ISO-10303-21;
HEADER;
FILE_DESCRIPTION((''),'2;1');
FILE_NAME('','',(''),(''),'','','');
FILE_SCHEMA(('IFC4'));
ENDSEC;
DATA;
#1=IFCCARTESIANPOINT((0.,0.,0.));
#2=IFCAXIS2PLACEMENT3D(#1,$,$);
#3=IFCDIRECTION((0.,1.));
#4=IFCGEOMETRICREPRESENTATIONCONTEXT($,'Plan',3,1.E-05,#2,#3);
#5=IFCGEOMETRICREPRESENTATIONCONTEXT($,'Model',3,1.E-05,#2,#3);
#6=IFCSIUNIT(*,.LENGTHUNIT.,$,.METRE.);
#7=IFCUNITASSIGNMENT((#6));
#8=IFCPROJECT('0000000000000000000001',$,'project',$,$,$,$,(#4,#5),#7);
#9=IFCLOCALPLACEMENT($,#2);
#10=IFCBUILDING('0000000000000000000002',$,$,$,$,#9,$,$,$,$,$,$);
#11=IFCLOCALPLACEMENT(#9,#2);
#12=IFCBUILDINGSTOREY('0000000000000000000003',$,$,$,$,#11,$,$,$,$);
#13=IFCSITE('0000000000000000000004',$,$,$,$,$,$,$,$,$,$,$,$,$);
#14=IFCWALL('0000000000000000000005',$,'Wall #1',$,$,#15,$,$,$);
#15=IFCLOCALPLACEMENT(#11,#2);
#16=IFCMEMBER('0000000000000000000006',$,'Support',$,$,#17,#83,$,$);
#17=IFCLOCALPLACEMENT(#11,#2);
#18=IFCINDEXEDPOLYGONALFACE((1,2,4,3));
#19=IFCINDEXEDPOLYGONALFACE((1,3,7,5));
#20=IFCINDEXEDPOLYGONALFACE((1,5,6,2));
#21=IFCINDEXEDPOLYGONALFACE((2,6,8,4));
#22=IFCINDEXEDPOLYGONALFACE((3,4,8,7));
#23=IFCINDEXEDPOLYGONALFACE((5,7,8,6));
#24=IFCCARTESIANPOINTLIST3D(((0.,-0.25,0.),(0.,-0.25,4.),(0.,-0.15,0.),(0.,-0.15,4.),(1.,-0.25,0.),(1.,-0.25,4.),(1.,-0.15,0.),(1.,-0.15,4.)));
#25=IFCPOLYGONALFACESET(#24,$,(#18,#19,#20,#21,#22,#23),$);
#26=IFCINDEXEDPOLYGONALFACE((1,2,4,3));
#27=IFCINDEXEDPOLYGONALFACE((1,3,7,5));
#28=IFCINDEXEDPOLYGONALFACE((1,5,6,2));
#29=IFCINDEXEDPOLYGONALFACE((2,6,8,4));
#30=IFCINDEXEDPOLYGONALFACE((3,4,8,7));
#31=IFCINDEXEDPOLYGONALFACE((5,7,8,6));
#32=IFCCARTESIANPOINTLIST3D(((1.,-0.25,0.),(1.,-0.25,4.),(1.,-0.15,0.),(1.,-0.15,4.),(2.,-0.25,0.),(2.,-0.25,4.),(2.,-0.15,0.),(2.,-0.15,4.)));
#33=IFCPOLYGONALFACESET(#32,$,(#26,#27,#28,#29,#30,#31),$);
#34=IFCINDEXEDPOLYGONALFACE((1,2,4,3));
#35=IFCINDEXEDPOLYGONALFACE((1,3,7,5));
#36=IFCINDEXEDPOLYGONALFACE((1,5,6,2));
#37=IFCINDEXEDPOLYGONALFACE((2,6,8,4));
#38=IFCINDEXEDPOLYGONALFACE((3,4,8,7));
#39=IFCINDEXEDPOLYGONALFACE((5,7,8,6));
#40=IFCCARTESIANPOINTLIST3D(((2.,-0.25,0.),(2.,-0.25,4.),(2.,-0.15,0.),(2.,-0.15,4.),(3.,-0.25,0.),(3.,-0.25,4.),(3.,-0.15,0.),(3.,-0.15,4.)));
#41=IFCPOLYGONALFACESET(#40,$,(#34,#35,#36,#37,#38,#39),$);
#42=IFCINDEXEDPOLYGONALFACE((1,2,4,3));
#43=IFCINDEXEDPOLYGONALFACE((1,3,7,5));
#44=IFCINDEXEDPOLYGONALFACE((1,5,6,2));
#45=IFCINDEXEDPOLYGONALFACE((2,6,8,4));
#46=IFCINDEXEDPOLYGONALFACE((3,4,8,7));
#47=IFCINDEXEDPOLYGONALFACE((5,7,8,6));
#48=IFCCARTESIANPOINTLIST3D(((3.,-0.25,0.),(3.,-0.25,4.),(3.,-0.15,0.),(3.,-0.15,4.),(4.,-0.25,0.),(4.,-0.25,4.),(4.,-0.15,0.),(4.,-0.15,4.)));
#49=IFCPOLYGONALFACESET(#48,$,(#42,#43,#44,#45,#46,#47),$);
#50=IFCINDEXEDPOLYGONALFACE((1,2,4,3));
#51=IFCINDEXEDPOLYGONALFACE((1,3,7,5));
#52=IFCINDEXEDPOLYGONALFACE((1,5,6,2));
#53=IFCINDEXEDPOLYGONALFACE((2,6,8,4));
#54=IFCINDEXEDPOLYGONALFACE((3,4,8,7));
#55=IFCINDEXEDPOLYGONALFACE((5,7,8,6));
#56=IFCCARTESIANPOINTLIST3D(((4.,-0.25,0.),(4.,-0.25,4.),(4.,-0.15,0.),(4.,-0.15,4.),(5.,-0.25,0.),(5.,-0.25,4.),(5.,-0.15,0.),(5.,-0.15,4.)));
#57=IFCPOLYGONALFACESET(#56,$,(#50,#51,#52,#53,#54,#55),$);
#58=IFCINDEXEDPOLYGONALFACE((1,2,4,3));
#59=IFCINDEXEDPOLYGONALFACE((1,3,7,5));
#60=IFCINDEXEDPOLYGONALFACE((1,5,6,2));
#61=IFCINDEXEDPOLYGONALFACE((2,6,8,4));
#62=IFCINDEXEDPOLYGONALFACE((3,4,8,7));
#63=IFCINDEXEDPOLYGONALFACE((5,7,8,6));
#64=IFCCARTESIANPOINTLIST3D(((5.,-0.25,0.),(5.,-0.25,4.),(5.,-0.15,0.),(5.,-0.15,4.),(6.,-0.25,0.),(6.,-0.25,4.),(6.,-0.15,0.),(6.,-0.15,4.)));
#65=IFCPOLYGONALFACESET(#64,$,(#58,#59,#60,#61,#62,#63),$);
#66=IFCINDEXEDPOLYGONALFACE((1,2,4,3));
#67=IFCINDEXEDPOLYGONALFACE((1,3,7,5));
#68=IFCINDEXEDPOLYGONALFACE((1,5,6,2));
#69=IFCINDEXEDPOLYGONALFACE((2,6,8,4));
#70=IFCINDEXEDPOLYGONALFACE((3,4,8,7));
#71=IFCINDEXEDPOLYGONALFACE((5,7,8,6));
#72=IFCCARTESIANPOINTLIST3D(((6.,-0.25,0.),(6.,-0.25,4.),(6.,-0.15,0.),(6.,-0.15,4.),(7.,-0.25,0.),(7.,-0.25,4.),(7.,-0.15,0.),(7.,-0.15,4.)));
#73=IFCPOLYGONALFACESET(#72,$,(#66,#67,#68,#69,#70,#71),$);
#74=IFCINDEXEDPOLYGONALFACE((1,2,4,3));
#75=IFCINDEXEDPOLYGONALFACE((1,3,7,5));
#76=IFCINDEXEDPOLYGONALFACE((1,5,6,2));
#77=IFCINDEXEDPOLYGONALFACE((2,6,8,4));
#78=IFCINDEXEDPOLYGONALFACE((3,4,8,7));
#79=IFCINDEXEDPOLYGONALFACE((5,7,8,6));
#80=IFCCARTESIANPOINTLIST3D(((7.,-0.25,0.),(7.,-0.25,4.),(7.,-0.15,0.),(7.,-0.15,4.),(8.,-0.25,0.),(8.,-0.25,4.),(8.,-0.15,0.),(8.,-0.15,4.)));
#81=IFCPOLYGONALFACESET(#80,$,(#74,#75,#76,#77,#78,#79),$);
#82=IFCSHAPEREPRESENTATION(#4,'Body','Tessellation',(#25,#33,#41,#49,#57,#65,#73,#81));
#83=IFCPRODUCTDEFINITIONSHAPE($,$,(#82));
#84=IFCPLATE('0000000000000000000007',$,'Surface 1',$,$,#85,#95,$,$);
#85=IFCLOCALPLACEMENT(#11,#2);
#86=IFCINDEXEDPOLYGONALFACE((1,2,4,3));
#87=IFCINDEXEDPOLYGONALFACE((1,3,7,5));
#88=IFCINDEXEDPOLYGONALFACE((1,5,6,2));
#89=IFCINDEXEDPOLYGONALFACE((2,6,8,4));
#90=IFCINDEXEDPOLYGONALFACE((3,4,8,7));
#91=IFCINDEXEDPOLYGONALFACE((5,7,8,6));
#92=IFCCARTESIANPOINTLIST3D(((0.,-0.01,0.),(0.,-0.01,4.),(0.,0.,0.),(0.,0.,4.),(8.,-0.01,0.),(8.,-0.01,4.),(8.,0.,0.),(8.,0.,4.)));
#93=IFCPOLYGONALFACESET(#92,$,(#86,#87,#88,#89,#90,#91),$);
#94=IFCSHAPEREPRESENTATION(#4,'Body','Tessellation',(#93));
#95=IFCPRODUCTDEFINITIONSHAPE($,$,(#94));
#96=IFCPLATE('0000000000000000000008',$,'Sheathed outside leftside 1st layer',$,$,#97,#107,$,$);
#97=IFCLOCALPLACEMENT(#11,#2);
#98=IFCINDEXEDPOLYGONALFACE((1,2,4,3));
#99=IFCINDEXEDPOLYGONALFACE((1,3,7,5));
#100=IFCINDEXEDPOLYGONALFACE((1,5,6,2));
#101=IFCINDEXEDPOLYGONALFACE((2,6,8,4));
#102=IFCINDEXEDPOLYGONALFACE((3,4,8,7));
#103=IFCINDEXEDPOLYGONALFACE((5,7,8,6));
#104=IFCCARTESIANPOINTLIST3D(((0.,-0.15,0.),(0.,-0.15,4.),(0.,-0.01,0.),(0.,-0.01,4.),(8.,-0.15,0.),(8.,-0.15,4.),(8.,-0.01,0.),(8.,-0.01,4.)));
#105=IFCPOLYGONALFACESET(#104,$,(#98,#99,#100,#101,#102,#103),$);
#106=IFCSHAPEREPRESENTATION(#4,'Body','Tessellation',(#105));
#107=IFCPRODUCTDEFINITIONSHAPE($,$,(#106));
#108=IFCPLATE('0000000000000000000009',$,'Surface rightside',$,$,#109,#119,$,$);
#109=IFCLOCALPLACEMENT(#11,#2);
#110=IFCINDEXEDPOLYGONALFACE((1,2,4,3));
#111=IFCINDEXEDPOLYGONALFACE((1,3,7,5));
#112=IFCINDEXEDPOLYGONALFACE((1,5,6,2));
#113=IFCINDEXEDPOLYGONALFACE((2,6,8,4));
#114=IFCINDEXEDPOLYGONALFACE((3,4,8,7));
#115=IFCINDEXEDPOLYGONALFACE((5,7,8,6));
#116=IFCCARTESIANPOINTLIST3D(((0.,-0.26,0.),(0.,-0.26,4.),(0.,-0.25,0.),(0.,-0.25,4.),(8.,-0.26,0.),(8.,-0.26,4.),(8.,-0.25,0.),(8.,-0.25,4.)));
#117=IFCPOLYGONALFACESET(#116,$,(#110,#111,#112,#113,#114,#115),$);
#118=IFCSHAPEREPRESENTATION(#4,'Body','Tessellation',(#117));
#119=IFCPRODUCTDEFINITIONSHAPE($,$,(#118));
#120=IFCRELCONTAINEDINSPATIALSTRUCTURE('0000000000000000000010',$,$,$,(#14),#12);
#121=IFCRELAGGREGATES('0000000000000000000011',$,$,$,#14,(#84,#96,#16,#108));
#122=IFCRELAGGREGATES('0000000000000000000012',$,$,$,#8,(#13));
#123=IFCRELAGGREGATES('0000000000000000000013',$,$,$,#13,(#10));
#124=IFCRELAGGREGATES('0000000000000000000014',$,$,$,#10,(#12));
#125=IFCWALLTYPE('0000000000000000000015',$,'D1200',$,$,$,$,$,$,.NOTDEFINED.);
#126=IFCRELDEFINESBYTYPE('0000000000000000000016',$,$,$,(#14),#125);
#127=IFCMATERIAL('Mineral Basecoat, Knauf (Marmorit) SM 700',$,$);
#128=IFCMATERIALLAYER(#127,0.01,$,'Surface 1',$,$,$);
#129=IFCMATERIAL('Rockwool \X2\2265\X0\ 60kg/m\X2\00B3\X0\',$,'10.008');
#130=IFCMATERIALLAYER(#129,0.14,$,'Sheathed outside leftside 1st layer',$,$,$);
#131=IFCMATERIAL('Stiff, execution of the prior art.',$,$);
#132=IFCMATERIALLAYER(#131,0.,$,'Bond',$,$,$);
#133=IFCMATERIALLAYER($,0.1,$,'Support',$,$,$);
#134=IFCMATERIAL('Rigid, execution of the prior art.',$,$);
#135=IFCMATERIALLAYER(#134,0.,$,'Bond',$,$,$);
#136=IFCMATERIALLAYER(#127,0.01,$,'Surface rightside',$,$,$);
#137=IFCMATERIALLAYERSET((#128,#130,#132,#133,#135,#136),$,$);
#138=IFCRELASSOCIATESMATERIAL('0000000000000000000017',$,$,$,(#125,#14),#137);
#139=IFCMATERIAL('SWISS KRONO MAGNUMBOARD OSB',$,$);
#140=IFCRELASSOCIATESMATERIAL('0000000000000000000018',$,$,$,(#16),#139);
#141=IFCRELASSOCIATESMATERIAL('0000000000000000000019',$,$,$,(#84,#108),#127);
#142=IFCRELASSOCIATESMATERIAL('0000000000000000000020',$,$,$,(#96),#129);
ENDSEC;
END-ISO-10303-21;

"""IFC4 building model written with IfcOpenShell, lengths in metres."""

from ifc_helpers import new_model, si_unit, direction, frame, frame_2d, origin, origin_with_axes, place, context, project, spatial, rectangle, extrude, material, layer, layer_set, type_object, element, aggregate, save


model = new_model("IFC4")

# Units and contexts
plan_context = context("Plan", 3, precision=1e-05, world=origin(), true_north=direction((0.0, 1.0)))
model_context = context("Model", 3, precision=1e-05, world=origin(), true_north=direction((0.0, 1.0)))
ifc_project = project(units=[si_unit("LENGTHUNIT", "METRE")], contexts=[plan_context, model_context])

# Site, building, storey
site = spatial("IfcSite", under=ifc_project)
building_placement = place(None, origin())
building = spatial("IfcBuilding", under=site, at=building_placement)
storey_placement = place(building_placement, origin())
storey = spatial("IfcBuildingStorey", under=building, at=storey_placement)

# Wall, member, plates
ifc_material_1 = material(Name="Mineral Basecoat, Knauf (Marmorit) SM 700")
ifc_layer_1 = layer(ifc_material_1, 0.01, Name="Surface 1")
ifc_material_2 = material(Name="Rockwool ≥ 60kg/m³", Category="10.008")
ifc_layer_2 = layer(ifc_material_2, 0.14, Name="Sheathed outside leftside 1st layer")
ifc_material_3 = material(Name="Stiff, execution of the prior art.")
ifc_layer_3 = layer(ifc_material_3, 0.0, Name="Bond")
ifc_layer_4 = layer(None, 0.1, Name="Support")
ifc_material_4 = material(Name="Rigid, execution of the prior art.")
ifc_layer_5 = layer(ifc_material_4, 0.0, Name="Bond")
ifc_layer_6 = layer(ifc_material_1, 0.01, Name="Surface rightside")
ifc_layer_set = layer_set([ifc_layer_1, ifc_layer_2, ifc_layer_3, ifc_layer_4, ifc_layer_5, ifc_layer_6])
wall_type = type_object("IfcWallType", Name="D1200", PredefinedType="NOTDEFINED", material=ifc_layer_set)
wall_placement = place(None, frame((0.0, 0.0, 0.0), z_axis=(0.0, -1.0, 0.0), x_axis=(1.0, 0.0, 0.0)))
wall = element("IfcWall", 1, at=wall_placement, inside=storey, type_object=wall_type, material=ifc_layer_set, Name="Wall #1")
ifc_material_5 = material(Name="SWISS KRONO MAGNUMBOARD OSB")
member_placement = place(wall_placement, origin())
member = element("IfcMember", 2, at=member_placement, material=ifc_material_5, Name="Support", context=plan_context, shape_type="SweptSolid", body=[
    extrude(rectangle(XDim=1.0, YDim=0.1, at=frame_2d((0.5, 0.05), x_axis=(1.0, 0.0))), frame((0.0, 4.0, 0.15), z_axis=(0.0, -1.0, 0.0), x_axis=(1.0, 0.0, 0.0)), (0.0, 0.0, 1.0), 4.0),
    extrude(rectangle(XDim=1.0, YDim=0.1, at=frame_2d((0.5, 0.05), x_axis=(1.0, 0.0))), frame((1.0, 4.0, 0.15), z_axis=(0.0, -1.0, 0.0), x_axis=(1.0, 0.0, 0.0)), (0.0, 0.0, 1.0), 4.0),
    extrude(rectangle(XDim=1.0, YDim=0.1, at=frame_2d((0.5, 0.05), x_axis=(1.0, 0.0))), frame((2.0, 4.0, 0.15), z_axis=(0.0, -1.0, 0.0), x_axis=(1.0, 0.0, 0.0)), (0.0, 0.0, 1.0), 4.0),
    extrude(rectangle(XDim=1.0, YDim=0.1, at=frame_2d((0.5, 0.05), x_axis=(1.0, 0.0))), frame((3.0, 4.0, 0.15), z_axis=(0.0, -1.0, 0.0), x_axis=(1.0, 0.0, 0.0)), (0.0, 0.0, 1.0), 4.0),
    extrude(rectangle(XDim=1.0, YDim=0.1, at=frame_2d((0.5, 0.05), x_axis=(1.0, 0.0))), frame((4.0, 4.0, 0.15), z_axis=(0.0, -1.0, 0.0), x_axis=(1.0, 0.0, 0.0)), (0.0, 0.0, 1.0), 4.0),
    extrude(rectangle(XDim=1.0, YDim=0.1, at=frame_2d((0.5, 0.05), x_axis=(1.0, 0.0))), frame((5.0, 4.0, 0.15), z_axis=(0.0, -1.0, 0.0), x_axis=(1.0, 0.0, 0.0)), (0.0, 0.0, 1.0), 4.0),
    extrude(rectangle(XDim=1.0, YDim=0.1, at=frame_2d((0.5, 0.05), x_axis=(1.0, 0.0))), frame((6.0, 4.0, 0.15), z_axis=(0.0, -1.0, 0.0), x_axis=(1.0, 0.0, 0.0)), (0.0, 0.0, 1.0), 4.0),
    extrude(rectangle(XDim=1.0, YDim=0.1, at=frame_2d((0.5, 0.05), x_axis=(1.0, 0.0))), frame((7.0, 4.0, 0.15), z_axis=(0.0, -1.0, 0.0), x_axis=(1.0, 0.0, 0.0)), (0.0, 0.0, 1.0), 4.0),
])
plate_1_placement = place(wall_placement, origin())
plate_1 = element("IfcPlate", 3, at=plate_1_placement, material=ifc_material_1, Name="Surface 1", context=plan_context, shape_type="SweptSolid", body=[
    extrude(rectangle(XDim=8.0, YDim=4.0, at=frame_2d((4.0, 2.0), x_axis=(1.0, 0.0))), origin_with_axes(), (0.0, 0.0, 1.0), 0.01),
])
plate_2_placement = place(wall_placement, origin())
plate_2 = element("IfcPlate", 4, at=plate_2_placement, material=ifc_material_2, Name="Sheathed outside leftside 1st layer", context=plan_context, shape_type="SweptSolid", body=[
    extrude(rectangle(XDim=8.0, YDim=4.0, at=frame_2d((4.0, 2.0), x_axis=(1.0, 0.0))), frame((0.0, 0.0, 0.01), z_axis=(0.0, 0.0, 1.0), x_axis=(1.0, 0.0, 0.0)), (0.0, 0.0, 1.0), 0.14),
])
plate_3_placement = place(wall_placement, origin())
plate_3 = element("IfcPlate", 5, at=plate_3_placement, material=ifc_material_1, Name="Surface rightside", context=plan_context, shape_type="SweptSolid", body=[
    extrude(rectangle(XDim=8.0, YDim=4.0, at=frame_2d((4.0, 2.0), x_axis=(1.0, 0.0))), frame((0.0, 0.0, 0.25), z_axis=(0.0, 0.0, 1.0), x_axis=(1.0, 0.0, 0.0)), (0.0, 0.0, 1.0), 0.01),
])
aggregate(wall, [plate_1, plate_2, member, plate_3])

save(model, "model.ifc")
